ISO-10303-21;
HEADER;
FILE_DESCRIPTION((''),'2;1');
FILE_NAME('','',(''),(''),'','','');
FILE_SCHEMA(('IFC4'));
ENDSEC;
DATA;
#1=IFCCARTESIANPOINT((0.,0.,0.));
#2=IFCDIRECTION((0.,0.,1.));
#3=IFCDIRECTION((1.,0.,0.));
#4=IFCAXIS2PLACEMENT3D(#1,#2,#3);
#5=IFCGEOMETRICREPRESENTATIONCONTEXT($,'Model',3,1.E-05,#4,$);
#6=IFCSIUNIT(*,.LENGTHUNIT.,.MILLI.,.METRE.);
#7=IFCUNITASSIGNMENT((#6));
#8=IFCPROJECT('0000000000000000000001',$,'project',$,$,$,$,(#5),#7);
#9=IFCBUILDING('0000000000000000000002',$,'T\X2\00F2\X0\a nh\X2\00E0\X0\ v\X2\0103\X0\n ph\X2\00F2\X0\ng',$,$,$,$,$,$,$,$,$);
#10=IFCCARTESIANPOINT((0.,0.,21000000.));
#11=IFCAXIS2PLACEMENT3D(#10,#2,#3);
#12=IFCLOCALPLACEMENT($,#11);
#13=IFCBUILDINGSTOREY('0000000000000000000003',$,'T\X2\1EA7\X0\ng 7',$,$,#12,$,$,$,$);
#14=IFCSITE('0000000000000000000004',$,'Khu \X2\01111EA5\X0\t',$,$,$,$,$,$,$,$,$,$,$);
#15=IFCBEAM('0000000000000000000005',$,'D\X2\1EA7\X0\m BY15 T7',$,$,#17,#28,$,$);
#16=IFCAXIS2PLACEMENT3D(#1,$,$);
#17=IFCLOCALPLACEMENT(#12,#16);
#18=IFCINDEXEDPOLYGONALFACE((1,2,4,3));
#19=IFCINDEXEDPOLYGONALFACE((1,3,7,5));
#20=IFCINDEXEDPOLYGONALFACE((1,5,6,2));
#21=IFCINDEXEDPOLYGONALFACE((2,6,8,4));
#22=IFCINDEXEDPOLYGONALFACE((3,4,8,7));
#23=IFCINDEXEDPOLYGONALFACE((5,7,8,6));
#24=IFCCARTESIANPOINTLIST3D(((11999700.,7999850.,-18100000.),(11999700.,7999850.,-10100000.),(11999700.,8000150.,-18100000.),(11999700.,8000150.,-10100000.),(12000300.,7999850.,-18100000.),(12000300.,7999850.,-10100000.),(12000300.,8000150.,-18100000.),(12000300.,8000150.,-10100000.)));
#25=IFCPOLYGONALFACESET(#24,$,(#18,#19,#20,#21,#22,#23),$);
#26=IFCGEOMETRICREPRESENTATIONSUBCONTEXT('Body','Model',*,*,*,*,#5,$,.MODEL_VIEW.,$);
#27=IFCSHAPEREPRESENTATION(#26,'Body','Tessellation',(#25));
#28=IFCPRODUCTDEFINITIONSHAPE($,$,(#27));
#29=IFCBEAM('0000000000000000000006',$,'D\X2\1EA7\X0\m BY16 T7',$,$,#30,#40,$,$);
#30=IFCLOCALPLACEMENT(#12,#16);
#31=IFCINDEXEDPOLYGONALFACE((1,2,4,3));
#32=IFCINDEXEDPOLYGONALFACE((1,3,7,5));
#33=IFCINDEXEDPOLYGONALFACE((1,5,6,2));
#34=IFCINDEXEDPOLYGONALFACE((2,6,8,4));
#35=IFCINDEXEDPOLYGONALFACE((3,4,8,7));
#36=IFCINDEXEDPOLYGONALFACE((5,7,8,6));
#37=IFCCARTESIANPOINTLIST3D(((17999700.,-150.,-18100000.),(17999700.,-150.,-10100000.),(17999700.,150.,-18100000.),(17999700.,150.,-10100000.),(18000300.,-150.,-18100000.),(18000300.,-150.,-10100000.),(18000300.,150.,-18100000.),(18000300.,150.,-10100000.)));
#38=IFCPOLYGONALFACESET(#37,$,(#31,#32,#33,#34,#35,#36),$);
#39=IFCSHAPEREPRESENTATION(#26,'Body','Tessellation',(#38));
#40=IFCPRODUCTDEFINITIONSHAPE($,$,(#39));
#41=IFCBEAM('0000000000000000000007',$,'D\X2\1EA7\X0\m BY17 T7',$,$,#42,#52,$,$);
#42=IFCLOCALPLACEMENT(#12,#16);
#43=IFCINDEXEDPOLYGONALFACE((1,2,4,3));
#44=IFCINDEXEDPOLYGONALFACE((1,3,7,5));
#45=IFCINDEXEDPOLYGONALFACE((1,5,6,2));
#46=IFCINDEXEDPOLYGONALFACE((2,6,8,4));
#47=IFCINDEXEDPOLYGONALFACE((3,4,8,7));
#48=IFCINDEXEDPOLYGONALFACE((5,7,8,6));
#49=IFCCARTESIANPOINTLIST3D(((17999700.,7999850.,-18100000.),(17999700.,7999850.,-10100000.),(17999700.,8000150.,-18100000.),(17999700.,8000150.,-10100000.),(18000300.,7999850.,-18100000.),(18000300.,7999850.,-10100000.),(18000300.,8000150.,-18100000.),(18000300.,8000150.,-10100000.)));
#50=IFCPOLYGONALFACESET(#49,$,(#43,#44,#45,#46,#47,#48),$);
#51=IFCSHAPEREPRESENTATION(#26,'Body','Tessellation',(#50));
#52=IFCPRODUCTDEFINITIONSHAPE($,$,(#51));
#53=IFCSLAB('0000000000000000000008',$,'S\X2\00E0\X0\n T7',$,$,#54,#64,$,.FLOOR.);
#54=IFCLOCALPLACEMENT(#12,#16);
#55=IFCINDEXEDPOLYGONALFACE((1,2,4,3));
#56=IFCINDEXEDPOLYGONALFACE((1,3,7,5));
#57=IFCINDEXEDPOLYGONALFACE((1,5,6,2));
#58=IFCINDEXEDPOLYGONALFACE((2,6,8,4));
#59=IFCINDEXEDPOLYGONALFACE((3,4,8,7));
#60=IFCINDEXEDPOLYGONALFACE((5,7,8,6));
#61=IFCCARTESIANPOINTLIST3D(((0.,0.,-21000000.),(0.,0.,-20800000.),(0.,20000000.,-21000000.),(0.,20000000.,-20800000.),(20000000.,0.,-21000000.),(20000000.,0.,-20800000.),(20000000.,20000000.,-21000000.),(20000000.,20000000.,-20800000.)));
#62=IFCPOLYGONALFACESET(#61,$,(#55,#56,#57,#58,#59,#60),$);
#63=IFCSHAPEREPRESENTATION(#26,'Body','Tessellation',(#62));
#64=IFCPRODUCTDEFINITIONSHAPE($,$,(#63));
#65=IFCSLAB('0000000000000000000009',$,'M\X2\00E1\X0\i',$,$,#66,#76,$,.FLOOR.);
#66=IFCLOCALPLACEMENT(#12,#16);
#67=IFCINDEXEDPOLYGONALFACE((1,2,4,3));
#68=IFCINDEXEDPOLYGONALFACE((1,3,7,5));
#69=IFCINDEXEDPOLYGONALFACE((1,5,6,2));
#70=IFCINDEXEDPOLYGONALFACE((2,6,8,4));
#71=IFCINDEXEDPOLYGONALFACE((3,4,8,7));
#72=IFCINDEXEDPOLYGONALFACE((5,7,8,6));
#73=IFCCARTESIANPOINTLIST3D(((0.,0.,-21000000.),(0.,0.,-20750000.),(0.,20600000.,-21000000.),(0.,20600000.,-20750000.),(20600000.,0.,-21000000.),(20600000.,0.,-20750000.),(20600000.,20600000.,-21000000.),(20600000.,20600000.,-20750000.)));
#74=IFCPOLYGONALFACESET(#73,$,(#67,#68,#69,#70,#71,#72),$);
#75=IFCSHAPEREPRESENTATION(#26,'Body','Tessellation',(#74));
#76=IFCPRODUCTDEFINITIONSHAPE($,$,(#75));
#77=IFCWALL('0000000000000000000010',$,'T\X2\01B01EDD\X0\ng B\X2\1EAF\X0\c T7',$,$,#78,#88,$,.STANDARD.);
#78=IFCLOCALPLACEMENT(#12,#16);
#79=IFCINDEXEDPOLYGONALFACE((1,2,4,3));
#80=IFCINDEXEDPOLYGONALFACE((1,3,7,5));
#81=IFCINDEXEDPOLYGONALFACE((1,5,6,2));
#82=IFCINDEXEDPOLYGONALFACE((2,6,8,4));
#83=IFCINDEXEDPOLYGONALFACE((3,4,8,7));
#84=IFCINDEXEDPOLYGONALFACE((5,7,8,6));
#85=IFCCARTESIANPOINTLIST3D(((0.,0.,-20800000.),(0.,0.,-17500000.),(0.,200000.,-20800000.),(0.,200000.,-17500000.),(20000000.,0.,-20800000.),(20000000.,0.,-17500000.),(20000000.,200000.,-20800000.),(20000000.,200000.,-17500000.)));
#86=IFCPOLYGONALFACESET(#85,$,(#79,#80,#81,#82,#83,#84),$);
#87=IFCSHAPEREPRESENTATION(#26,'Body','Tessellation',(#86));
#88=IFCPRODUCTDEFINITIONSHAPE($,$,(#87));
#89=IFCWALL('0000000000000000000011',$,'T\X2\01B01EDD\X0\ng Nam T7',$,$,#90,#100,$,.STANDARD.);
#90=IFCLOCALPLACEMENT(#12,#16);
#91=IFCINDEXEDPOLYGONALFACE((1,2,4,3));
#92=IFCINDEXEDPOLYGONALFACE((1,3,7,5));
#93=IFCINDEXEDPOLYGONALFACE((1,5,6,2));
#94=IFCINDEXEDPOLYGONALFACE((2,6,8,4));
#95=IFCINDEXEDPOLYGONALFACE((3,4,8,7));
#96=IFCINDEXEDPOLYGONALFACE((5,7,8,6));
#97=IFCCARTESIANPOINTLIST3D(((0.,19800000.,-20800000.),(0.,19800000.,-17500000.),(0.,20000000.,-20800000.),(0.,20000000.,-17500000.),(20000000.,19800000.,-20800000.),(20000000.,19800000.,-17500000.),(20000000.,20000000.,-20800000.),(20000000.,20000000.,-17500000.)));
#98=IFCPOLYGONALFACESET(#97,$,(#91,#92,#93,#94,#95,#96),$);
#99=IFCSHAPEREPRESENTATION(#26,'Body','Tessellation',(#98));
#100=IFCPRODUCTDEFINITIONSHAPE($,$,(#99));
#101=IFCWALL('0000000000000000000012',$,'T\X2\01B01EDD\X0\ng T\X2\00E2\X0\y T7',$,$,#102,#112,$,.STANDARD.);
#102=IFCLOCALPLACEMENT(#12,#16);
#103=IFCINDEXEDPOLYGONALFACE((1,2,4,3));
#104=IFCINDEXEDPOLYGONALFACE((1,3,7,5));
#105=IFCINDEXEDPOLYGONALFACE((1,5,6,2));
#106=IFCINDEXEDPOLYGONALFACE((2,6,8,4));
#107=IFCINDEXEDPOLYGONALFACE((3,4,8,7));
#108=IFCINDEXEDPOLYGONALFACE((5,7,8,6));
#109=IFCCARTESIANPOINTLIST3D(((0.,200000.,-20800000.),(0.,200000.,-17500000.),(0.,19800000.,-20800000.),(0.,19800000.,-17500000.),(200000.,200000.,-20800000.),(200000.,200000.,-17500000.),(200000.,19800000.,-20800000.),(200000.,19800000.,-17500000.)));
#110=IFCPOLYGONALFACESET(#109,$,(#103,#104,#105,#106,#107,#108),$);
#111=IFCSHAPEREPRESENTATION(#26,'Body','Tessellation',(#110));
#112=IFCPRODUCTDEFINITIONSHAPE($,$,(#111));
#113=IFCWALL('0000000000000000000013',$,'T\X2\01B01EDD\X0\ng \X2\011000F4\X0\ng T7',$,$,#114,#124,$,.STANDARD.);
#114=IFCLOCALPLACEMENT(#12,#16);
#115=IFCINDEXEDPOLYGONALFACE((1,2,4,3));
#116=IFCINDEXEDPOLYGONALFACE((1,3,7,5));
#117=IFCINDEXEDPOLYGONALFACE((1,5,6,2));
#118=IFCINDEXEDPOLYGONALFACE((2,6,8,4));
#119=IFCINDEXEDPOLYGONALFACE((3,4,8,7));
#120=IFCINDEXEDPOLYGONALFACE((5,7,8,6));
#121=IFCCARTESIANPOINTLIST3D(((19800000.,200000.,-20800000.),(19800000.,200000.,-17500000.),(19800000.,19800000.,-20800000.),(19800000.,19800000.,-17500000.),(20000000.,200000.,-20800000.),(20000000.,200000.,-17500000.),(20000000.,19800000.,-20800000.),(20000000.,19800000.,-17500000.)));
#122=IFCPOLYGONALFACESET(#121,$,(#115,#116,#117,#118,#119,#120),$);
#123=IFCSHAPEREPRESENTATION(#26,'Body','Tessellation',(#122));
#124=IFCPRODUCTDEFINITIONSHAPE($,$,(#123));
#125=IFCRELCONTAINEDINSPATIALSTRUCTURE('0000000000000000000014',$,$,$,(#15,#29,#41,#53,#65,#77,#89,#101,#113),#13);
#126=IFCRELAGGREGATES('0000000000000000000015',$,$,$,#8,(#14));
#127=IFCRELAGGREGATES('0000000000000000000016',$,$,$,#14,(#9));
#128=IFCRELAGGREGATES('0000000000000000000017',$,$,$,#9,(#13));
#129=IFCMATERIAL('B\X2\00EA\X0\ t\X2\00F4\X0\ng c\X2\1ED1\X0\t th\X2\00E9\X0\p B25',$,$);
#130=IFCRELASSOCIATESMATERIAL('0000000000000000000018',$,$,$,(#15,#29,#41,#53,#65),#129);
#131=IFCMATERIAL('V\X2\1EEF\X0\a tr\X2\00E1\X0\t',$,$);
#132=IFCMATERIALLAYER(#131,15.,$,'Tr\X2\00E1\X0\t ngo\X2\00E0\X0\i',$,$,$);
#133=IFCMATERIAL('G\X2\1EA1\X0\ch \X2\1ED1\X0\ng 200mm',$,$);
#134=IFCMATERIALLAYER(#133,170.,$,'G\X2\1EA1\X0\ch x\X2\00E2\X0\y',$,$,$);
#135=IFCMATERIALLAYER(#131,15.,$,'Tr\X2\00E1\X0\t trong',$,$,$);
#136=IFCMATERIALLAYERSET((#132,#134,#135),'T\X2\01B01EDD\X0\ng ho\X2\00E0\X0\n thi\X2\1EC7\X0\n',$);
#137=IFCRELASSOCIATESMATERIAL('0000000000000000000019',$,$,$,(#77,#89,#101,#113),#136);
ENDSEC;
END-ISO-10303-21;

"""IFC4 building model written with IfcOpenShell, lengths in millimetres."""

from ifc_helpers import new_model, entity, si_unit, frame, origin_with_axes, place, context, subcontext, project, spatial, indexed_curve, outline, extrude, material, layer, layer_set, layer_usage, element, save


model = new_model("IFC4")

# Units and contexts
model_context = context("Model", 3, precision=1e-05, world=origin_with_axes())
body_context = subcontext(model_context, "Body", "Model", "MODEL_VIEW")
ifc_project = project(units=[si_unit("LENGTHUNIT", "METRE", prefix="MILLI")], contexts=[model_context])

# Site, building, storey
site = spatial("IfcSite", under=ifc_project, Name="Khu đất")
building = spatial("IfcBuilding", under=site, Name="Tòa nhà văn phòng")
storey_placement = place(None, frame((0.0, 0.0, 21000000.0), z_axis=(0.0, 0.0, 1.0), x_axis=(1.0, 0.0, 0.0)))
storey = spatial("IfcBuildingStorey", under=building, at=storey_placement, Name="Tầng 7")

# Shared definitions
ifc_material_1 = material(Name="Bê tông cốt thép B25")

# Beams
for number, where, z_axis, x_axis, name in (
    (1, (12000000.0, 8000000.0, -18100000.0), (0.0, 0.0, 1.0), (0.0, 1.0, 0.0), "Dầm BY15 T7"),
    (2, (18000000.0, 0.0, -18100000.0), (0.0, 0.0, 1.0), (0.0, 1.0, 0.0), "Dầm BY16 T7"),
    (3, (18000000.0, 8000000.0, -18100000.0), (0.0, 0.0, 1.0), (0.0, 1.0, 0.0), "Dầm BY17 T7"),
):
    element("IfcBeam", number, at=place(storey_placement, frame(where, z_axis=z_axis, x_axis=x_axis)), inside=storey, material=ifc_material_1, Name=name, context=body_context, shape_type="SweptSolid", body=[
        extrude(entity("IfcRectangleProfileDef", None, None, None, 300.0, 600.0), origin_with_axes(), (0.0, 0.0, 1.0), 8000000.0),
    ])

# Slabs
slab_1_placement = place(storey_placement, frame((0.0, 0.0, -21000000.0), z_axis=(0.0, 0.0, 1.0), x_axis=(1.0, 0.0, 0.0)))
element("IfcSlab", 4, at=slab_1_placement, inside=storey, material=ifc_material_1, Name="Sàn T7", PredefinedType="FLOOR", context=body_context, shape_type="SweptSolid", body=[
    extrude(outline(indexed_curve([(0.0, 0.0), (20000000.0, 0.0), (20000000.0, 20000000.0), (0.0, 20000000.0), (0.0, 0.0)])), None, (0.0, 0.0, 1.0), 200000.0),
])
slab_2_placement = place(storey_placement, frame((0.0, 0.0, -21000000.0), z_axis=(0.0, 0.0, 1.0), x_axis=(1.0, 0.0, 0.0)))
element("IfcSlab", 5, at=slab_2_placement, inside=storey, material=ifc_material_1, Name="Mái", PredefinedType="FLOOR", context=body_context, shape_type="SweptSolid", body=[
    extrude(outline(indexed_curve([(0.0, 0.0), (20600000.0, 0.0), (20600000.0, 20600000.0), (0.0, 20600000.0), (0.0, 0.0)])), None, (0.0, 0.0, 1.0), 250000.0),
])

# Walls
ifc_material_2 = material(Name="Vữa trát")
ifc_layer_1 = layer(ifc_material_2, 15.0, Name="Trát ngoài")
ifc_material_3 = material(Name="Gạch ống 200mm")
ifc_layer_2 = layer(ifc_material_3, 170.0, Name="Gạch xây")
ifc_layer_3 = layer(ifc_material_2, 15.0, Name="Trát trong")
ifc_layer_set = layer_set([ifc_layer_1, ifc_layer_2, ifc_layer_3], Name="Tường hoàn thiện")
ifc_layer_usage_1 = layer_usage(ifc_layer_set, "AXIS2", "POSITIVE", 0.0)
wall_1_placement = place(storey_placement, frame((0.0, 0.0, -20800000.0), z_axis=(0.0, 0.0, 1.0), x_axis=(1.0, 0.0, 0.0)))
element("IfcWall", 6, at=wall_1_placement, inside=storey, material=ifc_layer_usage_1, Name="Tường Bắc T7", PredefinedType="STANDARD", context=body_context, shape_type="SweptSolid", body=[
    extrude(outline(indexed_curve([(0.0, 0.0), (0.0, 200000.0), (20000000.0, 200000.0), (20000000.0, 0.0), (0.0, 0.0)], self_intersect=False)), origin_with_axes(), (0.0, 0.0, 1.0), 3300000.0),
])
ifc_layer_usage_2 = layer_usage(ifc_layer_set, "AXIS2", "POSITIVE", 0.0)
wall_2_placement = place(storey_placement, frame((0.0, 19800000.0, -20800000.0), z_axis=(0.0, 0.0, 1.0), x_axis=(1.0, 0.0, 0.0)))
element("IfcWall", 7, at=wall_2_placement, inside=storey, material=ifc_layer_usage_2, Name="Tường Nam T7", PredefinedType="STANDARD", context=body_context, shape_type="SweptSolid", body=[
    extrude(outline(indexed_curve([(0.0, 0.0), (0.0, 200000.0), (20000000.0, 200000.0), (20000000.0, 0.0), (0.0, 0.0)], self_intersect=False)), origin_with_axes(), (0.0, 0.0, 1.0), 3300000.0),
])
ifc_layer_usage_3 = layer_usage(ifc_layer_set, "AXIS2", "POSITIVE", 0.0)
wall_3_placement = place(storey_placement, frame((0.0, 200000.0, -20800000.0), z_axis=(0.0, 0.0, 1.0), x_axis=(1.0, 0.0, 0.0)))
element("IfcWall", 8, at=wall_3_placement, inside=storey, material=ifc_layer_usage_3, Name="Tường Tây T7", PredefinedType="STANDARD", context=body_context, shape_type="SweptSolid", body=[
    extrude(outline(indexed_curve([(0.0, 0.0), (0.0, 19600000.0), (200000.0, 19600000.0), (200000.0, 0.0), (0.0, 0.0)], self_intersect=False)), origin_with_axes(), (0.0, 0.0, 1.0), 3300000.0),
])
ifc_layer_usage_4 = layer_usage(ifc_layer_set, "AXIS2", "POSITIVE", 0.0)
wall_4_placement = place(storey_placement, frame((19800000.0, 200000.0, -20800000.0), z_axis=(0.0, 0.0, 1.0), x_axis=(1.0, 0.0, 0.0)))
element("IfcWall", 9, at=wall_4_placement, inside=storey, material=ifc_layer_usage_4, Name="Tường Đông T7", PredefinedType="STANDARD", context=body_context, shape_type="SweptSolid", body=[
    extrude(outline(indexed_curve([(0.0, 0.0), (0.0, 19600000.0), (200000.0, 19600000.0), (200000.0, 0.0), (0.0, 0.0)], self_intersect=False)), origin_with_axes(), (0.0, 0.0, 1.0), 3300000.0),
])

save(model, "model.ifc")
